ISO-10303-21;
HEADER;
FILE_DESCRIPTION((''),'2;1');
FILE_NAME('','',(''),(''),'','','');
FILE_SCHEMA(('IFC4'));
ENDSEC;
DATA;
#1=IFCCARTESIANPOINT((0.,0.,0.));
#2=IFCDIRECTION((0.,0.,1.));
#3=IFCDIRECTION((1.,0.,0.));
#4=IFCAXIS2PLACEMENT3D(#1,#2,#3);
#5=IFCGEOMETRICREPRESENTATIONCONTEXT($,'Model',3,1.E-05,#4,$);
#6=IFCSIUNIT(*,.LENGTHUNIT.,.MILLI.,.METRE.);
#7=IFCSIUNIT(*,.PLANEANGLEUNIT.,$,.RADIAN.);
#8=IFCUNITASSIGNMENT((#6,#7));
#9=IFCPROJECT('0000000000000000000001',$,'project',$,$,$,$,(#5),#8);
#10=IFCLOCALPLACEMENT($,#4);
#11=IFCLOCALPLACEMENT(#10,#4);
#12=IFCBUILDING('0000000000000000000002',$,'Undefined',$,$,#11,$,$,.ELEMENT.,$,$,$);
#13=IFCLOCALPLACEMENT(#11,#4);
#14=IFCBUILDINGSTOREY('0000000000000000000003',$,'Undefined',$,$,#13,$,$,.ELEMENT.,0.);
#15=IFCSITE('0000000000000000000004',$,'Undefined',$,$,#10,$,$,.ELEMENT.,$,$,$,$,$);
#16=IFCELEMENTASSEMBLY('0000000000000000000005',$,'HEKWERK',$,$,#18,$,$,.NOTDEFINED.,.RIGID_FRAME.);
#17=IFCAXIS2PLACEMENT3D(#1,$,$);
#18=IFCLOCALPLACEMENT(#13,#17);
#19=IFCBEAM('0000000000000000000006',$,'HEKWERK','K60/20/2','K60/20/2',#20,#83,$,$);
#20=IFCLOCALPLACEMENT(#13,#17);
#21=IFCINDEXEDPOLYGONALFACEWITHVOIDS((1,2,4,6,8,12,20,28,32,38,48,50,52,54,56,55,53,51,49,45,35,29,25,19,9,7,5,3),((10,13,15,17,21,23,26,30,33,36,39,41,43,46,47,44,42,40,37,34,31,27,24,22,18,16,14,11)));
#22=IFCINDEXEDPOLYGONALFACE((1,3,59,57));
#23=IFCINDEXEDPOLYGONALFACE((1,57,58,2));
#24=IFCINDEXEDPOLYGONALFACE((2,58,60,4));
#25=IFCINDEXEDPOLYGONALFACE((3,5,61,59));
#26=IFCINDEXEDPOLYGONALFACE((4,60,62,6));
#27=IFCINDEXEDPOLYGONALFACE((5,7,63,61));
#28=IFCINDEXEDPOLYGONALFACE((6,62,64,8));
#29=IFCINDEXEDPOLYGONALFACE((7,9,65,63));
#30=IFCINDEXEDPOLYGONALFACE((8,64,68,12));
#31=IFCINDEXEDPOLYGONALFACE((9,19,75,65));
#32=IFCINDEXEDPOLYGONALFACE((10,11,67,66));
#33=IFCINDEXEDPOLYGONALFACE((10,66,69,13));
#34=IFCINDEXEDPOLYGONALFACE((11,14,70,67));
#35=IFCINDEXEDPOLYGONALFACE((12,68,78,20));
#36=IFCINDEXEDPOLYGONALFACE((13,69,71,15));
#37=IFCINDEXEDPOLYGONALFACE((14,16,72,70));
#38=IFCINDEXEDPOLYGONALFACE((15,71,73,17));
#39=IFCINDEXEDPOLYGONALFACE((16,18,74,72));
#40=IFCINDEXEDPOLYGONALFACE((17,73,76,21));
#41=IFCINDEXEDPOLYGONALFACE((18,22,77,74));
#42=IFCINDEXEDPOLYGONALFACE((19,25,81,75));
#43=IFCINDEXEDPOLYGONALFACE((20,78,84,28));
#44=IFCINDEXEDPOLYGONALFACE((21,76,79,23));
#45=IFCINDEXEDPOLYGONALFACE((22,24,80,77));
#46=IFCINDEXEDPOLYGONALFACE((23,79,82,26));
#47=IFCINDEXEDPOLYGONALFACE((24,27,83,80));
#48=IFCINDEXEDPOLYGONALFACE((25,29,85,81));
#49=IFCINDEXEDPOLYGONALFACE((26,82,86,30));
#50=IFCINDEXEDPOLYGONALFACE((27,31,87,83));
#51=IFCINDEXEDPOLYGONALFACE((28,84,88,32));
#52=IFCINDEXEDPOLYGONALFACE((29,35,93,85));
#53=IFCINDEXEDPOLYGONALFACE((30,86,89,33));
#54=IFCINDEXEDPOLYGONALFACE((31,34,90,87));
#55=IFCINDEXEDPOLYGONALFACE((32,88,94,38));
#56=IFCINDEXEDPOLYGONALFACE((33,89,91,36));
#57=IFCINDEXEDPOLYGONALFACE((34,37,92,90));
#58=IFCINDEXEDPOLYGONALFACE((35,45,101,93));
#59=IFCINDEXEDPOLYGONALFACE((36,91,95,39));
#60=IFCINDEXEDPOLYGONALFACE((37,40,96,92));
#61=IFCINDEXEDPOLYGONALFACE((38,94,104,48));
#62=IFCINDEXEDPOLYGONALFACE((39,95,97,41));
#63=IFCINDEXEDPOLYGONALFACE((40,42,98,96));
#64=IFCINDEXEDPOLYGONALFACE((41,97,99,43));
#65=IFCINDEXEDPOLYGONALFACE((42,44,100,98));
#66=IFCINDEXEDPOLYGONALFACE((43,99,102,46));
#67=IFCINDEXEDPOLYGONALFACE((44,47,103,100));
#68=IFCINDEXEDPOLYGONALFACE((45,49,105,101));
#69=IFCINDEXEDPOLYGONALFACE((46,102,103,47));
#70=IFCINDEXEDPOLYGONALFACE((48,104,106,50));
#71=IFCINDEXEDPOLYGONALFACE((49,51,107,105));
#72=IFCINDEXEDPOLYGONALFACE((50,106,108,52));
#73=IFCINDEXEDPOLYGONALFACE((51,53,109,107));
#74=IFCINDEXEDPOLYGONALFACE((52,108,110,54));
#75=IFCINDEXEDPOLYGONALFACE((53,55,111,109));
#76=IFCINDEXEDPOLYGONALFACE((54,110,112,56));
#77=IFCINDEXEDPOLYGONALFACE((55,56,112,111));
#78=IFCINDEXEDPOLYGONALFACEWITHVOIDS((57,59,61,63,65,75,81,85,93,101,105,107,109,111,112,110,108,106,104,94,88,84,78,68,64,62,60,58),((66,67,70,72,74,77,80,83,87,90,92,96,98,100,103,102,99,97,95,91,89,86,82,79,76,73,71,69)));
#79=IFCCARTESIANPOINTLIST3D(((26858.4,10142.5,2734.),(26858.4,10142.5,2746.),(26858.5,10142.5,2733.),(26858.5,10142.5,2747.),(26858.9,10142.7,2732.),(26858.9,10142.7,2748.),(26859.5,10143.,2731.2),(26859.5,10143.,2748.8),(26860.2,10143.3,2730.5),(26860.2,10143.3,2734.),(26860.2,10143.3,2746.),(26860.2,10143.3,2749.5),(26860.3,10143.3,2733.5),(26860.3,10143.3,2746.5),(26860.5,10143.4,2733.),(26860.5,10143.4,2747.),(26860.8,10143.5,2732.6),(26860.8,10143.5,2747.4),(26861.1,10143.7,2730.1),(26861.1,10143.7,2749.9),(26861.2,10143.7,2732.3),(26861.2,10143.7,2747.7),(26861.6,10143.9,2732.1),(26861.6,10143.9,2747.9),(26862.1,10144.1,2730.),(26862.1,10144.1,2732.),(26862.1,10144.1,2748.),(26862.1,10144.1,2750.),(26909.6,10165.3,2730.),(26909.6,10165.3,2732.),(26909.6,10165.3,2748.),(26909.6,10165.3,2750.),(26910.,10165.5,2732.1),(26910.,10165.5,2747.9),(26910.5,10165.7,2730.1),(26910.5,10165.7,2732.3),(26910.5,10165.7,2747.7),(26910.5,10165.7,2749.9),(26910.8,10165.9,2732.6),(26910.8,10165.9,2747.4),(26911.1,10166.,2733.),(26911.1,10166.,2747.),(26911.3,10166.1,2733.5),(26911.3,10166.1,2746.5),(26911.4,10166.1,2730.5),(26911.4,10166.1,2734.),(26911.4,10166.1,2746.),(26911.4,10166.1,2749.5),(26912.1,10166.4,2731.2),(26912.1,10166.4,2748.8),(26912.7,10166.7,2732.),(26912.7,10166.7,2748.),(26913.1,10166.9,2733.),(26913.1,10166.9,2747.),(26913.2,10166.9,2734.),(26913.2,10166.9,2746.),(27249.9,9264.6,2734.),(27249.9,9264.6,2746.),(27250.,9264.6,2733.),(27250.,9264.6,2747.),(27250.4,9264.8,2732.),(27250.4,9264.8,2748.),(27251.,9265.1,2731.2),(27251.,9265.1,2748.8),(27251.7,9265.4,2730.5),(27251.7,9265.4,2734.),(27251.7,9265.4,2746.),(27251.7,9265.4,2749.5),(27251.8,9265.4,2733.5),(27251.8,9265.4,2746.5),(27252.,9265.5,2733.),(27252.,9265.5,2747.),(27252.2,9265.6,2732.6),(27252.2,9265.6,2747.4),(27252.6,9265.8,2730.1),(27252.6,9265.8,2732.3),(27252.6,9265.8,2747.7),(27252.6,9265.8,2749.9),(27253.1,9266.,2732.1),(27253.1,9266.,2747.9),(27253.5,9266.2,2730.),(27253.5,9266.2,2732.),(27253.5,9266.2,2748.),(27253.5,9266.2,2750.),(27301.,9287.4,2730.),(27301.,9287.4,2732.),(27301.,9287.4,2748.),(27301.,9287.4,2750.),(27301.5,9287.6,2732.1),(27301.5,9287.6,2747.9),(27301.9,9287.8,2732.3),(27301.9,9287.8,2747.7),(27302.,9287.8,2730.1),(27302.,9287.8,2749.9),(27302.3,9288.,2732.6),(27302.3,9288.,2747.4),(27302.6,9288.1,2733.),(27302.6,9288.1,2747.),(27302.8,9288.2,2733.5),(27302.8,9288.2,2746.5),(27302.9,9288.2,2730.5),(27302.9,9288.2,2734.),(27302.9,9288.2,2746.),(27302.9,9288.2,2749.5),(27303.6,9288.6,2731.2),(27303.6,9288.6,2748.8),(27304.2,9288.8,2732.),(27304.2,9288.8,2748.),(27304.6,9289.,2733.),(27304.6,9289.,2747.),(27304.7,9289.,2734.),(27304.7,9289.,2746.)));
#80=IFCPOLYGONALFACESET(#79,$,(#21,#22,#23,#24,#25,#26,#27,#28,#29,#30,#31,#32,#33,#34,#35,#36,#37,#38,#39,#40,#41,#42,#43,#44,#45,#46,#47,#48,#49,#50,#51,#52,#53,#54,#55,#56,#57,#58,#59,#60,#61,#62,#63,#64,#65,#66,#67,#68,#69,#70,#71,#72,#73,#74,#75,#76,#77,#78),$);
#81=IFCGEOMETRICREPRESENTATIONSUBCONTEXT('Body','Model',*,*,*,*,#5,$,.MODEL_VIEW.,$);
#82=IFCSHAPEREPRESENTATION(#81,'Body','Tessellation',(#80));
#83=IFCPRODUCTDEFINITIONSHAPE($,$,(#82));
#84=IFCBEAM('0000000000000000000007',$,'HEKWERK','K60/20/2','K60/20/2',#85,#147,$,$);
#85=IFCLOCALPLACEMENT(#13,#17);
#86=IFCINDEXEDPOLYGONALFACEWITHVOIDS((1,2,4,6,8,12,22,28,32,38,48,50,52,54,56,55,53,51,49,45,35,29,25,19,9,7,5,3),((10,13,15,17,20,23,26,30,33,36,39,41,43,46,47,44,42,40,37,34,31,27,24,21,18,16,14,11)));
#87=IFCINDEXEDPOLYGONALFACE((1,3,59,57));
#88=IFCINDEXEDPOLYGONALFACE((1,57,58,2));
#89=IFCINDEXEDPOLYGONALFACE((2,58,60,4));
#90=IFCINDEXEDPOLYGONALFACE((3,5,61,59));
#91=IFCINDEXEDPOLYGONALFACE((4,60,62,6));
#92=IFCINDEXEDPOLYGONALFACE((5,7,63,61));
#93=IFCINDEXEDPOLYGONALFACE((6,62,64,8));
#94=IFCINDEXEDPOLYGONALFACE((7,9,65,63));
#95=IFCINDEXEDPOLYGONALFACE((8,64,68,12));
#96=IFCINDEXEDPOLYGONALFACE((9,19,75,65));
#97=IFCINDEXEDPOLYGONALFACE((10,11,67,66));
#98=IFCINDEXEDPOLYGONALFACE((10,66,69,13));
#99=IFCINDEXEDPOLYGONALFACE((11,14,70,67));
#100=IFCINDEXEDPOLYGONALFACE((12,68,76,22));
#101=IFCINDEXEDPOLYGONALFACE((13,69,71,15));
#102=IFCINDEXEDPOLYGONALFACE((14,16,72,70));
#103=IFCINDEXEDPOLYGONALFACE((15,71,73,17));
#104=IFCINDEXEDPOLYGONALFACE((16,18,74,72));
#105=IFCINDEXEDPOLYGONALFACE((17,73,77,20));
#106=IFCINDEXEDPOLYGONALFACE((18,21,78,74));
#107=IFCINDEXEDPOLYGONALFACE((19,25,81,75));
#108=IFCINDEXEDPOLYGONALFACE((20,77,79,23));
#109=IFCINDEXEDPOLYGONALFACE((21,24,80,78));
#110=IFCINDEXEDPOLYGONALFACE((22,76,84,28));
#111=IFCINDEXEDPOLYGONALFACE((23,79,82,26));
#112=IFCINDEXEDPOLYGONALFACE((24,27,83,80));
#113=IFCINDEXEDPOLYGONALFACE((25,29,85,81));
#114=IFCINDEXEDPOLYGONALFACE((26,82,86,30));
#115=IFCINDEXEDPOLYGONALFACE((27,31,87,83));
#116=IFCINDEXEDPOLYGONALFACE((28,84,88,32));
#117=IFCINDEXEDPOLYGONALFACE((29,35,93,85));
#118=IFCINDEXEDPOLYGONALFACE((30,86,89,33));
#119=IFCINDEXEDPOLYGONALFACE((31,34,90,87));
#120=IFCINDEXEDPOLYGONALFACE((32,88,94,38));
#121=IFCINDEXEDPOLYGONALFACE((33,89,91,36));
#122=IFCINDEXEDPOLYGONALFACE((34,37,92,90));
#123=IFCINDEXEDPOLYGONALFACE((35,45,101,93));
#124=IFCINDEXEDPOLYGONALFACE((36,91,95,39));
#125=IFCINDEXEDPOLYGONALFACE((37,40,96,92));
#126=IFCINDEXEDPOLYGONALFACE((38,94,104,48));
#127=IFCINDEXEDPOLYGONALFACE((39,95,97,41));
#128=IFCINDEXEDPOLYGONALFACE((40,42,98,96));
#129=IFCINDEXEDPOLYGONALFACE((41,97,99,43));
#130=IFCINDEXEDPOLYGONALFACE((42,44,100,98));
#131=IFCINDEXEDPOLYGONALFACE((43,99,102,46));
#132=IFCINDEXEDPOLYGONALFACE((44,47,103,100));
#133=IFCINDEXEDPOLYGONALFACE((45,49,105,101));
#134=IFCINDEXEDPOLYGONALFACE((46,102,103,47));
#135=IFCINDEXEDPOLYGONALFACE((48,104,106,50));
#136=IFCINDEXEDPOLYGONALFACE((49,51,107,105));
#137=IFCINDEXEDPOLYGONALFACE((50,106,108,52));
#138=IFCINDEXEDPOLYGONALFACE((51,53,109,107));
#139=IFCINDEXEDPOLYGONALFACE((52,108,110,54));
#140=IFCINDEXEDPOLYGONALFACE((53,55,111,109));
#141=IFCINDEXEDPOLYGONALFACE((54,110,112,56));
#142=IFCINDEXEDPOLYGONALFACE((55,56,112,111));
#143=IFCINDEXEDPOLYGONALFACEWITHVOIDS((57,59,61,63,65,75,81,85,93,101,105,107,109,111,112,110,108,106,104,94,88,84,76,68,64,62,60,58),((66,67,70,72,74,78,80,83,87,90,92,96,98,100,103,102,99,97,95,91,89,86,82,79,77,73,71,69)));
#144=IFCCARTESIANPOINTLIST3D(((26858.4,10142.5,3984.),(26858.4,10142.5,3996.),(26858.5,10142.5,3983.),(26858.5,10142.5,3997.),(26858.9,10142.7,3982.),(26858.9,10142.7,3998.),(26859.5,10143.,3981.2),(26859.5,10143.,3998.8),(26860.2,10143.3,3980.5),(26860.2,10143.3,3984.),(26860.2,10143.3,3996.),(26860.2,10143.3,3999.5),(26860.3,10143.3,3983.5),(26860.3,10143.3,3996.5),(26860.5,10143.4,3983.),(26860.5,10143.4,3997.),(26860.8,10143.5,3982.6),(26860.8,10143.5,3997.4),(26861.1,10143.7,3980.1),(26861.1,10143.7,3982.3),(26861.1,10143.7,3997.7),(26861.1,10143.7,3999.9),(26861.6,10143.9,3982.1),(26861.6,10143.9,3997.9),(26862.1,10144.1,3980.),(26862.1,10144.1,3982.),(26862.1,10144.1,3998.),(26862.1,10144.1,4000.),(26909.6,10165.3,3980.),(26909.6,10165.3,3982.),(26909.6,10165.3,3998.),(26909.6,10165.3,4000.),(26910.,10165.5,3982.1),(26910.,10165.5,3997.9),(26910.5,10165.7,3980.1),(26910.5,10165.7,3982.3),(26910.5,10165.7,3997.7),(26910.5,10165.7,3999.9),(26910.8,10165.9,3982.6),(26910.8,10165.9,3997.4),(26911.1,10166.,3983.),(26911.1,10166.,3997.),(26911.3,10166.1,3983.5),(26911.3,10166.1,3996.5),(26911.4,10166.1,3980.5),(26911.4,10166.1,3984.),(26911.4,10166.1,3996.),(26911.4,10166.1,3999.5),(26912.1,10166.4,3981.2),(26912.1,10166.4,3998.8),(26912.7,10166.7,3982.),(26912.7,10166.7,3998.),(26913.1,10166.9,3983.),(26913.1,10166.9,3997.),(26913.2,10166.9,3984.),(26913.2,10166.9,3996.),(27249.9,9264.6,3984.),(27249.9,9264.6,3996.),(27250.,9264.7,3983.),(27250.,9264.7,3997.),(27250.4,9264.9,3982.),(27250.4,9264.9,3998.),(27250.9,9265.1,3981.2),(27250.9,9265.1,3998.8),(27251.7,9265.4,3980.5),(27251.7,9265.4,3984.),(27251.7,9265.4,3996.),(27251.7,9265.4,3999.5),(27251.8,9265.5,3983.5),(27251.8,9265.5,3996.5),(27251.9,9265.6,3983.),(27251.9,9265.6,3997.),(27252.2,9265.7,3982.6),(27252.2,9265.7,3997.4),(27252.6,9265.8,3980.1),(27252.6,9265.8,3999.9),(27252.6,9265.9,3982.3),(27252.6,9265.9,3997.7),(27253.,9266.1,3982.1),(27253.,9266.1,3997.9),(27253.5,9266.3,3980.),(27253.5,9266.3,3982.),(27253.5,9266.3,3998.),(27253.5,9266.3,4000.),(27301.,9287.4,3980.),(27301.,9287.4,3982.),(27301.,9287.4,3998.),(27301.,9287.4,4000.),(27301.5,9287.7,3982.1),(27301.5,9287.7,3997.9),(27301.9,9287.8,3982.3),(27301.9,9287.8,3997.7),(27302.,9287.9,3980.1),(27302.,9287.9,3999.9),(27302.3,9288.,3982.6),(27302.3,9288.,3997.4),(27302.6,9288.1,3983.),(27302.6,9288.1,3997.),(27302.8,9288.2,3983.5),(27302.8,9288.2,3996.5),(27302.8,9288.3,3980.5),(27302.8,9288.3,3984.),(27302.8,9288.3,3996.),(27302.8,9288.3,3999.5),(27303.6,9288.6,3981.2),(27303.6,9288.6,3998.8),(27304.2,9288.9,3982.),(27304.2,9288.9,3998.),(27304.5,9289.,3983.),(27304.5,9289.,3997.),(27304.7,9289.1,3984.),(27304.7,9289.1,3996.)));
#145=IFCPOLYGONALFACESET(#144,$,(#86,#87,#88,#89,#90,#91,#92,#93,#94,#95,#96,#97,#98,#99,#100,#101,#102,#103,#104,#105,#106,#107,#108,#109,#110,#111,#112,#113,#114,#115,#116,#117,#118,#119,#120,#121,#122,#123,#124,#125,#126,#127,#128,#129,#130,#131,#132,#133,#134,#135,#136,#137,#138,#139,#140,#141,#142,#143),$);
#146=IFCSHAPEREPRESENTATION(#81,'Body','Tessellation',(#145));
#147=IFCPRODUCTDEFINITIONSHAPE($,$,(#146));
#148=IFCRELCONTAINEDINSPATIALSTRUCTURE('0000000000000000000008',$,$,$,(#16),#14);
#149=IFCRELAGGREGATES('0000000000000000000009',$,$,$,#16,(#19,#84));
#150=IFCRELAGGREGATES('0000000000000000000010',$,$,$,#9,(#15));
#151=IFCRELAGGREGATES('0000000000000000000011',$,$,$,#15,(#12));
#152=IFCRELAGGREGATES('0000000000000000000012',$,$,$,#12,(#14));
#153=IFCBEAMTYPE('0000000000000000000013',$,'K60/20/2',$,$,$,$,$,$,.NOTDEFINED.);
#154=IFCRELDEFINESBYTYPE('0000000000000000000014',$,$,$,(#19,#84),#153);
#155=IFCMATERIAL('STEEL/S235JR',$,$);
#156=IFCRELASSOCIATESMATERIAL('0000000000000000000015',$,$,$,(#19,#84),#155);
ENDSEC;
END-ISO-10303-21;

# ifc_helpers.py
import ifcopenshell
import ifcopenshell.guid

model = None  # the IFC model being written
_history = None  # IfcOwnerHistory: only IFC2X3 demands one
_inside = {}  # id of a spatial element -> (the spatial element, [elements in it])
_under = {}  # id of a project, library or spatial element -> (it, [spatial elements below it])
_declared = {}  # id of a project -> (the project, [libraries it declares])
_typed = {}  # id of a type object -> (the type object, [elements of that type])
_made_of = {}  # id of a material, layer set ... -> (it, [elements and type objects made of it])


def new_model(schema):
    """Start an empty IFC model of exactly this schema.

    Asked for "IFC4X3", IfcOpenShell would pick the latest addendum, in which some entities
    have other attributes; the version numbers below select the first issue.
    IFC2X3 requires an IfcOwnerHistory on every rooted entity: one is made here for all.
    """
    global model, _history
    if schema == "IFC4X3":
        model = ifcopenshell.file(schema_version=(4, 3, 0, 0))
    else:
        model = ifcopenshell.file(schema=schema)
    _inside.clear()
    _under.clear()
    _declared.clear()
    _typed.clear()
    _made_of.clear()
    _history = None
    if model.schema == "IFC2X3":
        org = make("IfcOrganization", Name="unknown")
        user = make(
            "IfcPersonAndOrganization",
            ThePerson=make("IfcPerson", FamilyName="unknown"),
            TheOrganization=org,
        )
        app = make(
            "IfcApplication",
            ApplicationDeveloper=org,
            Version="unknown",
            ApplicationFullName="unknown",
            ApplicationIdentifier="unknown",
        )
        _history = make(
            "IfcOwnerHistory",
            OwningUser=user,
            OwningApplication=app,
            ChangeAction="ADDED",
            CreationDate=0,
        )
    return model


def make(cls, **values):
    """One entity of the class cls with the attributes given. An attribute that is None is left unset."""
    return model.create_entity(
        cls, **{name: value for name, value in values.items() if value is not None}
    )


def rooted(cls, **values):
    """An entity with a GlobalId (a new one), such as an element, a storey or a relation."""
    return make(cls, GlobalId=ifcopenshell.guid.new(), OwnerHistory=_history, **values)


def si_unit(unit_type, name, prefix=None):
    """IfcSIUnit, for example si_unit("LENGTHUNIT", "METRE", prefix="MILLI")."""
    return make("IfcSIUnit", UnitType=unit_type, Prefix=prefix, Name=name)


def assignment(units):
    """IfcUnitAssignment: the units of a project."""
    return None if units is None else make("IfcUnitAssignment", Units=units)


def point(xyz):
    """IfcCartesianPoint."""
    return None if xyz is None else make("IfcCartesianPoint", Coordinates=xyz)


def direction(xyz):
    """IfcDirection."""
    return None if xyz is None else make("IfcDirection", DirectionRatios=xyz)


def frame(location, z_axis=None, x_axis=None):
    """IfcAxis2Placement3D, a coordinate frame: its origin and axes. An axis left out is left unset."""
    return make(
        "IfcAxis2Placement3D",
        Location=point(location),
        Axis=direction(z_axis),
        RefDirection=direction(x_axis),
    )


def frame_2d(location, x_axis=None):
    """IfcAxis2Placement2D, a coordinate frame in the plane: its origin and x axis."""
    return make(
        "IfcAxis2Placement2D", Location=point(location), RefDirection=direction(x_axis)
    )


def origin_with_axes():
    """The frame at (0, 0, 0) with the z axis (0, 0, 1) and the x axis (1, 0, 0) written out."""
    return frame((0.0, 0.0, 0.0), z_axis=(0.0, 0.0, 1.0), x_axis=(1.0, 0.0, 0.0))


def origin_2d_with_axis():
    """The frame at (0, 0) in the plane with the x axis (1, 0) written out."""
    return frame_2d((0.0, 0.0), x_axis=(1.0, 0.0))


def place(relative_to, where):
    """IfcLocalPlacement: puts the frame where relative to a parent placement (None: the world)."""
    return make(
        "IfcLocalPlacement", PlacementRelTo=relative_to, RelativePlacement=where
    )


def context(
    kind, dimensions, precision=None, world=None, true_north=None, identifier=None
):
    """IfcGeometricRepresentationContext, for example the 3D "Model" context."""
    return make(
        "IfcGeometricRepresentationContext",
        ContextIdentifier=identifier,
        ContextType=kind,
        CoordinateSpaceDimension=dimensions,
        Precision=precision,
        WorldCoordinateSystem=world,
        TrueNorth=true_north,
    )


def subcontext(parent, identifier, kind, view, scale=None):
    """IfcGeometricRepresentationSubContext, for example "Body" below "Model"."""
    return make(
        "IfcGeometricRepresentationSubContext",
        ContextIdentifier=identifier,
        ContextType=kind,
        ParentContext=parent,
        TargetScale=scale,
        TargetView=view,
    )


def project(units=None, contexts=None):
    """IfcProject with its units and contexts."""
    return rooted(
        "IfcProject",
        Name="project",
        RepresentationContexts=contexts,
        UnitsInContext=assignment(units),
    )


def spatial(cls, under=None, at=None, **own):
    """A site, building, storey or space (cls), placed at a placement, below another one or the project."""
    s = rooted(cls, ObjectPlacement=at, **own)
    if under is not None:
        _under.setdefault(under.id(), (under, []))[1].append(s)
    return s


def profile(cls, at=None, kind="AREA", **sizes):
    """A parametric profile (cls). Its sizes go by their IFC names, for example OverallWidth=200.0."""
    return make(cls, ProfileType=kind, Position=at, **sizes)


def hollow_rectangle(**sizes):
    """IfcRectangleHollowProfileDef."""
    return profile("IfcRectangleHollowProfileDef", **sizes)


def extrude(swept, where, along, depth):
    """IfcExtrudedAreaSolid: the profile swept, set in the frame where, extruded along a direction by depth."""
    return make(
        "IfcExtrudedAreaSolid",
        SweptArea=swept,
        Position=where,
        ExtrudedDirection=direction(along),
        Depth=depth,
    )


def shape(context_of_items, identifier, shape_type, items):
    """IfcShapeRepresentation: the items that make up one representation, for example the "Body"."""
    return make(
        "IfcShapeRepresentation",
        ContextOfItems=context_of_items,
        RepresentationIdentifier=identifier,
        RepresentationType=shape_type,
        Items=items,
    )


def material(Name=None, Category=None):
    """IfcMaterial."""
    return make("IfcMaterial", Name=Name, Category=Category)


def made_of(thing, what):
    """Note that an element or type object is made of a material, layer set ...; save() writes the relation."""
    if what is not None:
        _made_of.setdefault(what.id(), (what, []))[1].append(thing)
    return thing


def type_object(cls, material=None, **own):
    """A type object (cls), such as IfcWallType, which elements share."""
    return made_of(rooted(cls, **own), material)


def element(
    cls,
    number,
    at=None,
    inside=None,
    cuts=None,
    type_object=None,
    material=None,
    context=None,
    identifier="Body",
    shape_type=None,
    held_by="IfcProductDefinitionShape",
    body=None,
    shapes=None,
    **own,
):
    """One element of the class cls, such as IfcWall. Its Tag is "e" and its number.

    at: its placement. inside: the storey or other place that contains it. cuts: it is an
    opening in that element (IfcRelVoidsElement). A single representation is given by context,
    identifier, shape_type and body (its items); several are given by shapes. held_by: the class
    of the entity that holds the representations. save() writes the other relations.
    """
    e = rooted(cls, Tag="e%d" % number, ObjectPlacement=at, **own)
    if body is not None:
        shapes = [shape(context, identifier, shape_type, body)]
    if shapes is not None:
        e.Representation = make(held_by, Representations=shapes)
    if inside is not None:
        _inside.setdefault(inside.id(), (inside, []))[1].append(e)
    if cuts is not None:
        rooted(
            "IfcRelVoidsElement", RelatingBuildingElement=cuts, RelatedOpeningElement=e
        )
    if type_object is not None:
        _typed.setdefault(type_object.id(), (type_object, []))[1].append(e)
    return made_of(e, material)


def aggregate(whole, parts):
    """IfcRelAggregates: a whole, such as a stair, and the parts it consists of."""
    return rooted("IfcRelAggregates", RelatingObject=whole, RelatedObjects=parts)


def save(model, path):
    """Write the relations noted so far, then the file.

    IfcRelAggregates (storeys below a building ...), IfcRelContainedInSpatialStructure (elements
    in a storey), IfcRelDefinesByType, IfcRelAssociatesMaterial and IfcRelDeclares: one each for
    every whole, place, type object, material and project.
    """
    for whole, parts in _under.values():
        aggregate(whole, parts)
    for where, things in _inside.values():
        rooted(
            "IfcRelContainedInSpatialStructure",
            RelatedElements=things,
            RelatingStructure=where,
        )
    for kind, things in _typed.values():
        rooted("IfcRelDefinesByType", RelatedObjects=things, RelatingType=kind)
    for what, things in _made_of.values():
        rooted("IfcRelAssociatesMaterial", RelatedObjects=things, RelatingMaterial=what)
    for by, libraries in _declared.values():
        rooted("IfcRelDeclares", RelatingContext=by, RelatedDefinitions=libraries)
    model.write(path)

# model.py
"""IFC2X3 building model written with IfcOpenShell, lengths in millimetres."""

from ifc_helpers import new_model, si_unit, frame, origin_with_axes, origin_2d_with_axis, place, context, subcontext, project, spatial, hollow_rectangle, extrude, material, type_object, element, aggregate, save


model = new_model("IFC2X3")

# Units and contexts
model_context = context("Model", 3, precision=1e-05, world=origin_with_axes())
body_context = subcontext(model_context, "Body", "Model", "MODEL_VIEW")
ifc_project = project(units=[si_unit("LENGTHUNIT", "METRE", prefix="MILLI"), si_unit("PLANEANGLEUNIT", "RADIAN")], contexts=[model_context])

# Site, building, storey
site_placement = place(None, origin_with_axes())
site = spatial("IfcSite", under=ifc_project, at=site_placement, Name="Undefined", CompositionType="ELEMENT")
building_placement = place(site_placement, origin_with_axes())
building = spatial("IfcBuilding", under=site, at=building_placement, Name="Undefined", CompositionType="ELEMENT")
storey_placement = place(building_placement, origin_with_axes())
storey = spatial("IfcBuildingStorey", under=building, at=storey_placement, Name="Undefined", CompositionType="ELEMENT", Elevation=0.0)

# Element assembly, beams
assembly_1_placement = place(storey_placement, origin_with_axes())
assembly_1 = element("IfcElementAssembly", 1, at=assembly_1_placement, inside=storey, Name="HEKWERK", AssemblyPlace="NOTDEFINED", PredefinedType="RIGID_FRAME")
ifc_material_1 = material(Name="STEEL/S235JR")
beam_type_1 = type_object("IfcBeamType", Name="K60/20/2", PredefinedType="NOTDEFINED")
beam_1_placement = place(assembly_1_placement, frame((26885.8, 10154.7, 2740.0), z_axis=(0.913309, 0.407267, 0.0), x_axis=(0.407267, -0.913309, 0.0)))
beam_1 = element("IfcBeam", 2, at=beam_1_placement, type_object=beam_type_1, material=ifc_material_1, Name="HEKWERK", Description="K60/20/2", ObjectType="K60/20/2", context=body_context, shape_type="SweptSolid", body=[
    extrude(hollow_rectangle(XDim=20.0, YDim=60.0, WallThickness=2.0, InnerFilletRadius=2.0, OuterFilletRadius=4.0, at=origin_2d_with_axis()), frame((961.2, 0.0, 0.0), z_axis=(-1.0, 0.0, 0.0), x_axis=(0.0, -1.0, 0.0)), (0.0, 0.0, 1.0), 961.2),
])
beam_2_placement = place(assembly_1_placement, frame((26885.8, 10154.7, 3990.0), z_axis=(0.913309, 0.407268, 0.0), x_axis=(0.407268, -0.913309, 0.0)))
beam_2 = element("IfcBeam", 3, at=beam_2_placement, type_object=beam_type_1, material=ifc_material_1, Name="HEKWERK", Description="K60/20/2", ObjectType="K60/20/2", context=body_context, shape_type="SweptSolid", body=[
    extrude(hollow_rectangle(XDim=20.0, YDim=60.0, WallThickness=2.0, InnerFilletRadius=2.0, OuterFilletRadius=4.0, at=origin_2d_with_axis()), frame((961.2, 0.0, 0.0), z_axis=(-1.0, 0.0, 0.0), x_axis=(0.0, -1.0, 0.0)), (0.0, 0.0, 1.0), 961.2),
])

aggregate(assembly_1, [beam_1, beam_2])

save(model, "model.ifc")
